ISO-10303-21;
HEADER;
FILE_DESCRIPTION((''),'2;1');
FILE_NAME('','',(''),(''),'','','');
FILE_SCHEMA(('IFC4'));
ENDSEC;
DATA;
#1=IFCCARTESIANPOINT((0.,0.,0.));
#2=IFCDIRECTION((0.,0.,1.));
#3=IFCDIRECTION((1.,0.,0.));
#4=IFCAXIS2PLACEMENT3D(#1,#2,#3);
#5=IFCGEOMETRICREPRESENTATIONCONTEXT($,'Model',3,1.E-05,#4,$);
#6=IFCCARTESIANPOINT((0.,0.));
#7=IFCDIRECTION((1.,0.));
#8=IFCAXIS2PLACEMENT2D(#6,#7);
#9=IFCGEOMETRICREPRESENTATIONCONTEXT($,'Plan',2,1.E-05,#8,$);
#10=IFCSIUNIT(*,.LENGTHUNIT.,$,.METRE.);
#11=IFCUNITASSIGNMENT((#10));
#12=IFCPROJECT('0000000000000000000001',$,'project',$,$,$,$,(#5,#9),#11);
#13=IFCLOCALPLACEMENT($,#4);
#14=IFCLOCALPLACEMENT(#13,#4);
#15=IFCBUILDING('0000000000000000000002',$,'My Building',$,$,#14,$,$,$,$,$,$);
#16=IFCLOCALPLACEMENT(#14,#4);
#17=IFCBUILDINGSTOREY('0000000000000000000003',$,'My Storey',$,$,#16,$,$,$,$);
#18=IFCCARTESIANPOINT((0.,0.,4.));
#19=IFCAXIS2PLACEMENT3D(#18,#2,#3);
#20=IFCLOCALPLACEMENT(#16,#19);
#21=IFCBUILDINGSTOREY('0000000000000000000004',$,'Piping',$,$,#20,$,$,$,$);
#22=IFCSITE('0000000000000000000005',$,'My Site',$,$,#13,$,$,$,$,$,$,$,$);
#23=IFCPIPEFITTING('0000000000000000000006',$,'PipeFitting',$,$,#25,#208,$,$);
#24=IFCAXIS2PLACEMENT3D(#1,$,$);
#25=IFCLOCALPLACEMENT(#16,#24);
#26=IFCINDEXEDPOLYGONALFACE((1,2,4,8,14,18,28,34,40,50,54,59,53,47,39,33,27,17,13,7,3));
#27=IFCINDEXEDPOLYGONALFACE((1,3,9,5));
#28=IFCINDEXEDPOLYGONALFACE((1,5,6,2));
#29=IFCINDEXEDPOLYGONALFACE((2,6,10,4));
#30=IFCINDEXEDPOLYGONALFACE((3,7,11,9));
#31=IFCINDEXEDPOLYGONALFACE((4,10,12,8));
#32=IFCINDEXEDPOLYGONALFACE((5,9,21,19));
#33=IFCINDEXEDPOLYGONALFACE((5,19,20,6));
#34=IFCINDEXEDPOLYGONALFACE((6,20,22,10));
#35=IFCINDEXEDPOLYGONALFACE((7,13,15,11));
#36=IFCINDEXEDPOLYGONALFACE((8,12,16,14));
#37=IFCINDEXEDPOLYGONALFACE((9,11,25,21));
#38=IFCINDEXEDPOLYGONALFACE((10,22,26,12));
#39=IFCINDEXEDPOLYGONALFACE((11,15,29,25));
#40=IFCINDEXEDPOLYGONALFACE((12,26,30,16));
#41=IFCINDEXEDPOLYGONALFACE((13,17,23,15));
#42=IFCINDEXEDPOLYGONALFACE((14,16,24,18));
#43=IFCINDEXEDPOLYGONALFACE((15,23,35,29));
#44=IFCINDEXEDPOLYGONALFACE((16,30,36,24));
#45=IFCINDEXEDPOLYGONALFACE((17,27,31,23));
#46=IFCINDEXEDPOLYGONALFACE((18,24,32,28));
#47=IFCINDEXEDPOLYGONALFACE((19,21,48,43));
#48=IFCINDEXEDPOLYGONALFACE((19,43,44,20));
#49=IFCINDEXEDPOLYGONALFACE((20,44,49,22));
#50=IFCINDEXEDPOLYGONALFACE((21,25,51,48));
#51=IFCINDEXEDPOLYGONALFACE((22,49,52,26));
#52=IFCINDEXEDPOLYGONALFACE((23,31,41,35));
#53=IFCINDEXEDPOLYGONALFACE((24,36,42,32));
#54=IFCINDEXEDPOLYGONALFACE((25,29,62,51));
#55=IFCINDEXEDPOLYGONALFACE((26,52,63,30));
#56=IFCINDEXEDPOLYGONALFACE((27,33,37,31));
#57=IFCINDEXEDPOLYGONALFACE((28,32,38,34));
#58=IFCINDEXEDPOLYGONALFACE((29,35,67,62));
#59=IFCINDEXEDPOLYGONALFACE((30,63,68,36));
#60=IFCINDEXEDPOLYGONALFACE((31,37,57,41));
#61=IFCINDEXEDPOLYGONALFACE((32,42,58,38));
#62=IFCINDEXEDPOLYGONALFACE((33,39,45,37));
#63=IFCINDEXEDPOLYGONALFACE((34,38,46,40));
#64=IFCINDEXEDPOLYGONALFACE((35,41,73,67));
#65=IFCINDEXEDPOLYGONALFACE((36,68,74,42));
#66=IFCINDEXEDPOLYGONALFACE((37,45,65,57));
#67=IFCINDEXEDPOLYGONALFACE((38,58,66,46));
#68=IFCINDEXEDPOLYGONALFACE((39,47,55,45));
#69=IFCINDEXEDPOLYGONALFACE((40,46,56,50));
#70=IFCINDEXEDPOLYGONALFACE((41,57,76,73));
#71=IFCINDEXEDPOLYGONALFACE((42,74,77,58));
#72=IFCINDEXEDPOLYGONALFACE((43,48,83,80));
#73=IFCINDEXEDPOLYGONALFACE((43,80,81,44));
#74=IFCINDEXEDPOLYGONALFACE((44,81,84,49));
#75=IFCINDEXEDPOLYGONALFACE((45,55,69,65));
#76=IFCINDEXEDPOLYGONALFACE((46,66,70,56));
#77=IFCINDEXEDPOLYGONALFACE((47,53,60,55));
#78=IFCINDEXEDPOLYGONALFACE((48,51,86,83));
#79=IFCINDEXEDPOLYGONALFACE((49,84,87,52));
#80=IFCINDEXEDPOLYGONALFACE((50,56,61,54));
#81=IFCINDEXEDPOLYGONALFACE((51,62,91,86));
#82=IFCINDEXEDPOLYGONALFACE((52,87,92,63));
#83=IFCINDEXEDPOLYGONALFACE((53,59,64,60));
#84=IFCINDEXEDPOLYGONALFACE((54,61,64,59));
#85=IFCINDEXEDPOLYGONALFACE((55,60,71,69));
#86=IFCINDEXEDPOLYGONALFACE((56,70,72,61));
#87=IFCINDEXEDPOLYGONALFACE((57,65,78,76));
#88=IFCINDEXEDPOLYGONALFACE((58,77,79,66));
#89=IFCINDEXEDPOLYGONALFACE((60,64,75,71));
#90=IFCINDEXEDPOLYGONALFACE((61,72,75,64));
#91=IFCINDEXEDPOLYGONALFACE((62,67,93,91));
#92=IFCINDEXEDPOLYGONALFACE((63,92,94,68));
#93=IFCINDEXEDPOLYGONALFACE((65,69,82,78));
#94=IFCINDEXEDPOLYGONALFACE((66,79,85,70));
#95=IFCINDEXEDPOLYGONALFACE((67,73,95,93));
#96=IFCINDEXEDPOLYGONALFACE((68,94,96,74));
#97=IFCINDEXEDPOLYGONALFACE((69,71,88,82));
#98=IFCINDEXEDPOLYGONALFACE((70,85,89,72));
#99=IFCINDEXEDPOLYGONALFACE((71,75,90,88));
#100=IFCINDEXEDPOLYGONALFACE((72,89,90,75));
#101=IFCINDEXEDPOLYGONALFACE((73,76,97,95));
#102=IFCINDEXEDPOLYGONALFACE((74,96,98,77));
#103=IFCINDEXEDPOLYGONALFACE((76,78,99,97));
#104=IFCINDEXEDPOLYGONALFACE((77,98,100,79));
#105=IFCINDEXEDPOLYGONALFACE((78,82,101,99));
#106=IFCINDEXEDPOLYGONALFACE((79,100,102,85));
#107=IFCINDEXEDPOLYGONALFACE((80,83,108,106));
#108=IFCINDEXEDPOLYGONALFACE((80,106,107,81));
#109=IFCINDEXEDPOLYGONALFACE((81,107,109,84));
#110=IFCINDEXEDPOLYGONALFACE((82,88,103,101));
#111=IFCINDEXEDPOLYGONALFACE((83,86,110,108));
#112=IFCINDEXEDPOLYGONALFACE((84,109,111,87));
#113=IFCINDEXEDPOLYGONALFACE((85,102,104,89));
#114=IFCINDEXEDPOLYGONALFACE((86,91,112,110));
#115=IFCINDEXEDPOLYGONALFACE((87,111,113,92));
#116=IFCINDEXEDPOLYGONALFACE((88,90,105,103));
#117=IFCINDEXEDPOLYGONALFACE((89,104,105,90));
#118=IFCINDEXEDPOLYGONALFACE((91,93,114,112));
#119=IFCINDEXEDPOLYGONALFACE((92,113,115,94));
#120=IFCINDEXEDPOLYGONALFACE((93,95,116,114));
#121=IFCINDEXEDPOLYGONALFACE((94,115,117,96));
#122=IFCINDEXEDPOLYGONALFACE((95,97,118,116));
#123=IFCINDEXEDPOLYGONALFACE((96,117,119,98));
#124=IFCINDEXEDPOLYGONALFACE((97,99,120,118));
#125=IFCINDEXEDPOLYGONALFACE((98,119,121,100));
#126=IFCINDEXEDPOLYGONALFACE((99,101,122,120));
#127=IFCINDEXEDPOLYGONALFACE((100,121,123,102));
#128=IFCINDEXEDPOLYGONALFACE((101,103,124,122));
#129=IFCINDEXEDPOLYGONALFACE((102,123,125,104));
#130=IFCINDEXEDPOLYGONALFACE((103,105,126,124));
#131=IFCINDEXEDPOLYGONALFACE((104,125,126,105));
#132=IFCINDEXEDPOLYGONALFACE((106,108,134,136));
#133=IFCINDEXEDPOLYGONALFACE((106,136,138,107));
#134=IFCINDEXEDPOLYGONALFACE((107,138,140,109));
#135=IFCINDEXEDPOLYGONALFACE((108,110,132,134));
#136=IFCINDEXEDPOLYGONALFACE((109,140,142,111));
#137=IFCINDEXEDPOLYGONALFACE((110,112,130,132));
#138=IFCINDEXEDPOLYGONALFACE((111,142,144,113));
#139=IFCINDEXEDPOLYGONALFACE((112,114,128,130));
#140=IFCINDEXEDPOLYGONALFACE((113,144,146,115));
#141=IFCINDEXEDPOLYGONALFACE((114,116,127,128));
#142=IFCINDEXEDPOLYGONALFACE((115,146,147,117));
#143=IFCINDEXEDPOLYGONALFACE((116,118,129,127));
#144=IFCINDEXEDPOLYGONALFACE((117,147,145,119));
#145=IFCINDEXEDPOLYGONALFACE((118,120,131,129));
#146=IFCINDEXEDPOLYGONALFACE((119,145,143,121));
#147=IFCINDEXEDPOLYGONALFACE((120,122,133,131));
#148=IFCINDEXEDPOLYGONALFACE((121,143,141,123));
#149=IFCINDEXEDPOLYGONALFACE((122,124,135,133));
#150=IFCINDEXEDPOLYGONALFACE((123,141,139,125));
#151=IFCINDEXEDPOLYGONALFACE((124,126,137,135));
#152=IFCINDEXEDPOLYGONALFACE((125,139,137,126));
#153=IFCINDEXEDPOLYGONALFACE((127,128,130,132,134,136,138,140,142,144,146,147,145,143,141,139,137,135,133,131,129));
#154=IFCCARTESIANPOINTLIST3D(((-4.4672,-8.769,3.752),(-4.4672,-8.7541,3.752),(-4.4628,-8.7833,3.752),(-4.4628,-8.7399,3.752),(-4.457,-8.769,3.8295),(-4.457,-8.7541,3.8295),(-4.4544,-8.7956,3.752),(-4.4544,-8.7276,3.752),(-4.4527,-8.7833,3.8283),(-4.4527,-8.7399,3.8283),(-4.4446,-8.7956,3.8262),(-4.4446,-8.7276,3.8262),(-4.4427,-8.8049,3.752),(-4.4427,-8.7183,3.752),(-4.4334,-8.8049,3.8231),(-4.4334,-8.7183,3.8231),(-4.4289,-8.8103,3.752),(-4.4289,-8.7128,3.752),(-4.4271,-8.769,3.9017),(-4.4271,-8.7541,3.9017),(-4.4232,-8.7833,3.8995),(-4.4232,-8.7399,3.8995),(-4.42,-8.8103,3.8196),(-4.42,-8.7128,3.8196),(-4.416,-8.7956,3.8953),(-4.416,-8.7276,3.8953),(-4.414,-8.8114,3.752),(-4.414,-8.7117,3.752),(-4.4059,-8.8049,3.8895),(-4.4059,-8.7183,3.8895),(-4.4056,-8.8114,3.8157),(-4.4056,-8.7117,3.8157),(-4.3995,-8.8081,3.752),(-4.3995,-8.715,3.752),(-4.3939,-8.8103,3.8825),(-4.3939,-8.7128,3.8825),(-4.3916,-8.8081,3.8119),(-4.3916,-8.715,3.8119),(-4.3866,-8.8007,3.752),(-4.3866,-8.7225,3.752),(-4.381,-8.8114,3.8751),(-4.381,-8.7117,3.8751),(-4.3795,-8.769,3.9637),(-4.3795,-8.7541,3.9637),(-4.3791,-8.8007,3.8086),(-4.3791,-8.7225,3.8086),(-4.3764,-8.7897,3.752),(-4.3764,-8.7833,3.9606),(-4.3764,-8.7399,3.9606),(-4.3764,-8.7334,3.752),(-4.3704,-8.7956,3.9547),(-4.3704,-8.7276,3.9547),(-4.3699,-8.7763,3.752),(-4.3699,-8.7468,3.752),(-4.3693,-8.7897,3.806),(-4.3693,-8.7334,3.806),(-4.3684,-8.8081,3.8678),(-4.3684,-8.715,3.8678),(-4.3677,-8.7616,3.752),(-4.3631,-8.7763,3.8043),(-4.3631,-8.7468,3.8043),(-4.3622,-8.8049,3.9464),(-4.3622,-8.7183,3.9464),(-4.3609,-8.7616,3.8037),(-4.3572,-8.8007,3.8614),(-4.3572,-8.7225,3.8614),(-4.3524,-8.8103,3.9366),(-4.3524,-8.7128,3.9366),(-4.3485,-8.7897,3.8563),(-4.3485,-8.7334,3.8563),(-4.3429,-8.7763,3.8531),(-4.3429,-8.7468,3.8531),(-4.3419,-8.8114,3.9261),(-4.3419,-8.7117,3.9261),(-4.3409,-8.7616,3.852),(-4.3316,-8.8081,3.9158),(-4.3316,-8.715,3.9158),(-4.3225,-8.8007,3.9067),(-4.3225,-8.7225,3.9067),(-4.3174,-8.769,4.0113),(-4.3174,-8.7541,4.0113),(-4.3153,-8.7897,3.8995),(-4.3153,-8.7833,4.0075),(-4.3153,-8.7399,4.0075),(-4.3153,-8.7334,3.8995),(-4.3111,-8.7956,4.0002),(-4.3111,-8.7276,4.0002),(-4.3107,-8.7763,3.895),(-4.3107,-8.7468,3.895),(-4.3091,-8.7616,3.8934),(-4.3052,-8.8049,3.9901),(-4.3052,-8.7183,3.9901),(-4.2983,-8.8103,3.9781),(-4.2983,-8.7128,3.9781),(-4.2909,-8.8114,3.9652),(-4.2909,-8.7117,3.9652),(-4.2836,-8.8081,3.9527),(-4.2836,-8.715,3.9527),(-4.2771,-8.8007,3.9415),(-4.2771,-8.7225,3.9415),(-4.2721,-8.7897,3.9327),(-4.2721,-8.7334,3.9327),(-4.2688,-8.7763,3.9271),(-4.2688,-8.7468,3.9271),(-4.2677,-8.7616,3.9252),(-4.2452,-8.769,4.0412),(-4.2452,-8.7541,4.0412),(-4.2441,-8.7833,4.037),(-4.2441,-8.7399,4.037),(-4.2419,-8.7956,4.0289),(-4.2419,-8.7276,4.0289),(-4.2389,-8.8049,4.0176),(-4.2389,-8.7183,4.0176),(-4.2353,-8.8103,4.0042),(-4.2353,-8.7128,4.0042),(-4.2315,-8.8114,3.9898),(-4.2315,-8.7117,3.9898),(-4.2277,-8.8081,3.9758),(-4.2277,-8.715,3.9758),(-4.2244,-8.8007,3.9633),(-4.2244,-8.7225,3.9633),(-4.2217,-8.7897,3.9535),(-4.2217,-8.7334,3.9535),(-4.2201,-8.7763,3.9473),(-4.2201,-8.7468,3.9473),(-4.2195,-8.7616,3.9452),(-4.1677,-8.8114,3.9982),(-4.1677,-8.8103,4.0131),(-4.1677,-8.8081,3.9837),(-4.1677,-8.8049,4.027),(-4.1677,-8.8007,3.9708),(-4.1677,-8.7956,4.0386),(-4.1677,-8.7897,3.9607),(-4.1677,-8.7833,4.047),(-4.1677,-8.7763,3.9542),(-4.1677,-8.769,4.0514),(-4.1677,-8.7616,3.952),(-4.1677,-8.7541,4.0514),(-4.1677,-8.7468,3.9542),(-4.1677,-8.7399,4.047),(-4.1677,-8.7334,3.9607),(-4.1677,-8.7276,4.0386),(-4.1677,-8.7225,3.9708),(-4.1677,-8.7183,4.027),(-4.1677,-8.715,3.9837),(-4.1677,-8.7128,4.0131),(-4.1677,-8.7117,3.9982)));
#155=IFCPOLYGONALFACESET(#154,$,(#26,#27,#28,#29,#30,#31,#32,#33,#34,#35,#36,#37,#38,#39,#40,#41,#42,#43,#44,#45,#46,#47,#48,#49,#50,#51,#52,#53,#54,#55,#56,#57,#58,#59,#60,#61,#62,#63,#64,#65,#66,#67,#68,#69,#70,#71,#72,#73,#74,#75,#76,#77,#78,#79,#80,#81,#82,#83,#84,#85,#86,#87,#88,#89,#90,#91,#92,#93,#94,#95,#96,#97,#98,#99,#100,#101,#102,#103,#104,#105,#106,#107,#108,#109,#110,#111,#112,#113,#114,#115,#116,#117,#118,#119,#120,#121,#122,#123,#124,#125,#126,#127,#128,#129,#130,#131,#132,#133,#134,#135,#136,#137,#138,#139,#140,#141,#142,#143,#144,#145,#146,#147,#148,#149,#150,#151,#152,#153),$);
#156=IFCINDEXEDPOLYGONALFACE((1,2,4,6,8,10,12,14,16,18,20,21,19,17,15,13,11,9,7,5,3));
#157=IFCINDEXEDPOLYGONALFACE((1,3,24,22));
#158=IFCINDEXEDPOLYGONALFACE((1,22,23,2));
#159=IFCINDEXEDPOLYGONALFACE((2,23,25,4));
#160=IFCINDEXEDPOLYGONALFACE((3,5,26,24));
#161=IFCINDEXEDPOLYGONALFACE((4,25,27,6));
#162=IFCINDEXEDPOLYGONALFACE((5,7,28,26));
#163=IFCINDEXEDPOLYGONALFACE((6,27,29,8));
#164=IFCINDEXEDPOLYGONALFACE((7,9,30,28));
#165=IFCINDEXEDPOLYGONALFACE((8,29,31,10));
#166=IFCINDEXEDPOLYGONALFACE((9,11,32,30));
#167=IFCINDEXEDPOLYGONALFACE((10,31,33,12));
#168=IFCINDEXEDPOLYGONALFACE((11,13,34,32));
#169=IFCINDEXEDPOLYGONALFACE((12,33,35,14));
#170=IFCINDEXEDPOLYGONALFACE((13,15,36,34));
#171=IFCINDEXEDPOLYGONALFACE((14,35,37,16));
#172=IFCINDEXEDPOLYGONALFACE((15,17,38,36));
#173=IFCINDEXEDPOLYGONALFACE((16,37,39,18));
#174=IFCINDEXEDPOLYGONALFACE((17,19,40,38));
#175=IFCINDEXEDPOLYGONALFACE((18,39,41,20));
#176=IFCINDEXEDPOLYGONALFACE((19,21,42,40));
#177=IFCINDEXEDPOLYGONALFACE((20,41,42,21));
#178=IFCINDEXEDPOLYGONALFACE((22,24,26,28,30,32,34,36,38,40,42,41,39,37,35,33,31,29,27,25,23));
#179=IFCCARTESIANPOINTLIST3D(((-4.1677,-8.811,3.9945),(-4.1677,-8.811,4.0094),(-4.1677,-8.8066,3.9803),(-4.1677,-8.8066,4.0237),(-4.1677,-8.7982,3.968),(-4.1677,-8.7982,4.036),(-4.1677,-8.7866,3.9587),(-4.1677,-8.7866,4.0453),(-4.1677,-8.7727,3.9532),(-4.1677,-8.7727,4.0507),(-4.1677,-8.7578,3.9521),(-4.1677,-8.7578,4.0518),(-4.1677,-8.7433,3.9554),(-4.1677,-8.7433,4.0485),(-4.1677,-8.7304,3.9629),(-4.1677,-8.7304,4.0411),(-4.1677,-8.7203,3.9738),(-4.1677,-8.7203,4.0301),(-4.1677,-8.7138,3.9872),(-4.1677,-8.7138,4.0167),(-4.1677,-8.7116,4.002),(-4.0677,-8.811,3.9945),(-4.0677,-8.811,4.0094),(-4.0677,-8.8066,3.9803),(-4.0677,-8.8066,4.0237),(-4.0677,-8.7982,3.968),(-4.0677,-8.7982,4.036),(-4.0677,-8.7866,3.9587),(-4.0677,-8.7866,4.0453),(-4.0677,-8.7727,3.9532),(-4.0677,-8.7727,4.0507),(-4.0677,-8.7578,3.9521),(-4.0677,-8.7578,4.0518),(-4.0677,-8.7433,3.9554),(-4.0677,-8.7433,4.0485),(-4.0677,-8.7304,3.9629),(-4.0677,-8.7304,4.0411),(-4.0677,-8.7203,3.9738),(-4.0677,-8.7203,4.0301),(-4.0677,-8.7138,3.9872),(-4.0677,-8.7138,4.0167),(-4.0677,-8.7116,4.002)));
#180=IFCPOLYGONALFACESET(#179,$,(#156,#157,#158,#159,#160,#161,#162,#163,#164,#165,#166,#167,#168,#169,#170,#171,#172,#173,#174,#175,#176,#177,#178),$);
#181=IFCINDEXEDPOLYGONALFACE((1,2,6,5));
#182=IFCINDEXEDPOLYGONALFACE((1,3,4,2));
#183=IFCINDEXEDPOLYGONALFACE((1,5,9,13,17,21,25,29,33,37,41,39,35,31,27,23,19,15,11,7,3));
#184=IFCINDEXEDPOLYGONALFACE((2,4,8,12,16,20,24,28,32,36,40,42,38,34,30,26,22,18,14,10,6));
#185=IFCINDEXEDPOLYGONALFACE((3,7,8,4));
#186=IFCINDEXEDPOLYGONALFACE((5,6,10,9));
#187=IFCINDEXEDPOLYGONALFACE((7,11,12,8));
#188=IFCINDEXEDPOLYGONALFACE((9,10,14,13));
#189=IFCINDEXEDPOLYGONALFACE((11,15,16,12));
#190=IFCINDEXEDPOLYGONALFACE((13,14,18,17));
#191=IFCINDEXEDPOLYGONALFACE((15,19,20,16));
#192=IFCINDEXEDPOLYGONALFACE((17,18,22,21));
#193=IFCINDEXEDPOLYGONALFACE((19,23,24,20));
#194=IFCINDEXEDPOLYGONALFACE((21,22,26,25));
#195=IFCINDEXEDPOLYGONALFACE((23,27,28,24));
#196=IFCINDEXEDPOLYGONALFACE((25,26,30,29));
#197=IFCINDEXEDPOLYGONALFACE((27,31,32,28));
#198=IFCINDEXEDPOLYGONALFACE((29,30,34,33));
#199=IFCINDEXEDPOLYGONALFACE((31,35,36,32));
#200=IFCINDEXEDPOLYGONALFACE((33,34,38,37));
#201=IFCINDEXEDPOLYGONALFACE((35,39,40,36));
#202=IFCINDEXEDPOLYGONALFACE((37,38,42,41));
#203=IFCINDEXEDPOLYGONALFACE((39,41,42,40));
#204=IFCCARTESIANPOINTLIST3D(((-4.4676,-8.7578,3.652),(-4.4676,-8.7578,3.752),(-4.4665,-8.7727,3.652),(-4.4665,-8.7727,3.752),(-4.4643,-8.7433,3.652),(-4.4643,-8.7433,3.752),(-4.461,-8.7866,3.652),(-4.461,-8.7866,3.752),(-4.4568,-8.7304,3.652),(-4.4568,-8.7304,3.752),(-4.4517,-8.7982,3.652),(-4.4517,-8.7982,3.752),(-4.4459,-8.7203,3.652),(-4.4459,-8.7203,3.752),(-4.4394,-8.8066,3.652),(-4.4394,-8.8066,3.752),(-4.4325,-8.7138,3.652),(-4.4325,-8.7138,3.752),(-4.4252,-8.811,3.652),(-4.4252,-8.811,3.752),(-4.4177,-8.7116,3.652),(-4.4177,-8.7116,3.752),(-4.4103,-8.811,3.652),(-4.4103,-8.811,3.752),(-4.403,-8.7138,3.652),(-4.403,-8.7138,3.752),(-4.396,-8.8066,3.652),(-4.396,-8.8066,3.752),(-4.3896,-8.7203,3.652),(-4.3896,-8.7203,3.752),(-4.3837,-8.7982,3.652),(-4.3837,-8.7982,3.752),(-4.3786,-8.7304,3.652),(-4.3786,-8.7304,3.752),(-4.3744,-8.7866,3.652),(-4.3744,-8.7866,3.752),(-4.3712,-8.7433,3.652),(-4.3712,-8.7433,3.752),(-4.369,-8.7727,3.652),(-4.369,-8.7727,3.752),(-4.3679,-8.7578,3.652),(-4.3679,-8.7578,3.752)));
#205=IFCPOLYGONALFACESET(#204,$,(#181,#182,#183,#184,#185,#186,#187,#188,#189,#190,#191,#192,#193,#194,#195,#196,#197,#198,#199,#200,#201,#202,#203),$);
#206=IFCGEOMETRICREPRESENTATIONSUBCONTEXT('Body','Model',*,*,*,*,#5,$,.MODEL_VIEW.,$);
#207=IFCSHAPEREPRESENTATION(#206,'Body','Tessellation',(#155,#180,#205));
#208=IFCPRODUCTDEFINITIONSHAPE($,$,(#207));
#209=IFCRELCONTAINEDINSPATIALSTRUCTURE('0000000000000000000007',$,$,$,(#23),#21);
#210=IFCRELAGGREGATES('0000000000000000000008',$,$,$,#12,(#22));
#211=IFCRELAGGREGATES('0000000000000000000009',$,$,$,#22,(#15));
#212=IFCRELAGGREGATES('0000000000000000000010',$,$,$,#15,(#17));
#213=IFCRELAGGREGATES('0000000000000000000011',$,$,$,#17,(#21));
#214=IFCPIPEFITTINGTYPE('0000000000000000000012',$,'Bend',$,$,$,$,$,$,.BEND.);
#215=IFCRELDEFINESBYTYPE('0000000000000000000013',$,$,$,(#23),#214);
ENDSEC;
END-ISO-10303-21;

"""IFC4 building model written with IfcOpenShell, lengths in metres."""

from ifc_helpers import new_model, entity, si_unit, frame, origin_with_axes, origin_2d_with_axis, place, context, subcontext, project, spatial, circle, extrude, source, transform, mapped, type_object, type_shapes, element, save


model = new_model("IFC4")

# Units and contexts
model_context = context("Model", 3, precision=1e-05, world=origin_with_axes())
plan_context = context("Plan", 2, precision=1e-05, world=origin_2d_with_axis())
body_context = subcontext(model_context, "Body", "Model", "MODEL_VIEW")
ifc_project = project(units=[si_unit("LENGTHUNIT", "METRE")], contexts=[model_context, plan_context])

# Site, building, storeys
site_placement = place(None, origin_with_axes())
site = spatial("IfcSite", under=ifc_project, at=site_placement, Name="My Site")
building_placement = place(site_placement, origin_with_axes())
building = spatial("IfcBuilding", under=site, at=building_placement, Name="My Building")
storey_1_placement = place(building_placement, origin_with_axes())
storey_1 = spatial("IfcBuildingStorey", under=building, at=storey_1_placement, Name="My Storey")
storey_2_placement = place(storey_1_placement, frame((0.0, 0.0, 4.0), z_axis=(0.0, 0.0, 1.0), x_axis=(1.0, 0.0, 0.0)))
storey_2 = spatial("IfcBuildingStorey", under=storey_1, at=storey_2_placement, Name="Piping")

# Shared definitions
pipe_fitting_type_1 = type_object("IfcPipeFittingType", Name="Bend", PredefinedType="BEND")
shared_shape = source(origin_with_axes(), body_context, "Body", "SolidModel", [
    entity("IfcSweptDiskSolid", entity("IfcIndexedPolyCurve", entity("IfcCartesianPointList3D", [[0.0, 0.0, -0.1], [0.0, -0.0732, -0.2768], [0.0, -0.25, -0.35]]), [entity("IfcArcIndex", [1, 2, 3])]), 0.05),
    extrude(circle(Radius=0.05), origin_with_axes(), (0.0, 0.0, -1.0), 0.1),
    extrude(circle(Radius=0.05), frame((0.0, -0.25, -0.35), z_axis=(0.0, -1.0, 0.0), x_axis=(1.0, 0.0, 0.0)), (0.0, 0.0, 1.0), 0.1),
])
type_shapes(pipe_fitting_type_1, [shared_shape])

# Pipe fitting
for number, where, z_axis, x_axis, name in (
    (1, (-4.0677, -8.7616, 0.002), (1.0, 0.0, 0.0), (0.0, 1.0, 0.0), "PipeFitting"),
):
    element("IfcPipeFitting", number, at=place(storey_2_placement, frame(where, z_axis=z_axis, x_axis=x_axis)), inside=storey_2, type_object=pipe_fitting_type_1, Name=name, context=body_context, shape_type="MappedRepresentation", body=[
        mapped(shared_shape, transform((0.0, 0.0, 0.0), x_axis=(1.0, 0.0, 0.0), y_axis=(0.0, 1.0, 0.0), z_axis=(0.0, 0.0, 1.0), scale=1.0)),
    ])

save(model, "model.ifc")
